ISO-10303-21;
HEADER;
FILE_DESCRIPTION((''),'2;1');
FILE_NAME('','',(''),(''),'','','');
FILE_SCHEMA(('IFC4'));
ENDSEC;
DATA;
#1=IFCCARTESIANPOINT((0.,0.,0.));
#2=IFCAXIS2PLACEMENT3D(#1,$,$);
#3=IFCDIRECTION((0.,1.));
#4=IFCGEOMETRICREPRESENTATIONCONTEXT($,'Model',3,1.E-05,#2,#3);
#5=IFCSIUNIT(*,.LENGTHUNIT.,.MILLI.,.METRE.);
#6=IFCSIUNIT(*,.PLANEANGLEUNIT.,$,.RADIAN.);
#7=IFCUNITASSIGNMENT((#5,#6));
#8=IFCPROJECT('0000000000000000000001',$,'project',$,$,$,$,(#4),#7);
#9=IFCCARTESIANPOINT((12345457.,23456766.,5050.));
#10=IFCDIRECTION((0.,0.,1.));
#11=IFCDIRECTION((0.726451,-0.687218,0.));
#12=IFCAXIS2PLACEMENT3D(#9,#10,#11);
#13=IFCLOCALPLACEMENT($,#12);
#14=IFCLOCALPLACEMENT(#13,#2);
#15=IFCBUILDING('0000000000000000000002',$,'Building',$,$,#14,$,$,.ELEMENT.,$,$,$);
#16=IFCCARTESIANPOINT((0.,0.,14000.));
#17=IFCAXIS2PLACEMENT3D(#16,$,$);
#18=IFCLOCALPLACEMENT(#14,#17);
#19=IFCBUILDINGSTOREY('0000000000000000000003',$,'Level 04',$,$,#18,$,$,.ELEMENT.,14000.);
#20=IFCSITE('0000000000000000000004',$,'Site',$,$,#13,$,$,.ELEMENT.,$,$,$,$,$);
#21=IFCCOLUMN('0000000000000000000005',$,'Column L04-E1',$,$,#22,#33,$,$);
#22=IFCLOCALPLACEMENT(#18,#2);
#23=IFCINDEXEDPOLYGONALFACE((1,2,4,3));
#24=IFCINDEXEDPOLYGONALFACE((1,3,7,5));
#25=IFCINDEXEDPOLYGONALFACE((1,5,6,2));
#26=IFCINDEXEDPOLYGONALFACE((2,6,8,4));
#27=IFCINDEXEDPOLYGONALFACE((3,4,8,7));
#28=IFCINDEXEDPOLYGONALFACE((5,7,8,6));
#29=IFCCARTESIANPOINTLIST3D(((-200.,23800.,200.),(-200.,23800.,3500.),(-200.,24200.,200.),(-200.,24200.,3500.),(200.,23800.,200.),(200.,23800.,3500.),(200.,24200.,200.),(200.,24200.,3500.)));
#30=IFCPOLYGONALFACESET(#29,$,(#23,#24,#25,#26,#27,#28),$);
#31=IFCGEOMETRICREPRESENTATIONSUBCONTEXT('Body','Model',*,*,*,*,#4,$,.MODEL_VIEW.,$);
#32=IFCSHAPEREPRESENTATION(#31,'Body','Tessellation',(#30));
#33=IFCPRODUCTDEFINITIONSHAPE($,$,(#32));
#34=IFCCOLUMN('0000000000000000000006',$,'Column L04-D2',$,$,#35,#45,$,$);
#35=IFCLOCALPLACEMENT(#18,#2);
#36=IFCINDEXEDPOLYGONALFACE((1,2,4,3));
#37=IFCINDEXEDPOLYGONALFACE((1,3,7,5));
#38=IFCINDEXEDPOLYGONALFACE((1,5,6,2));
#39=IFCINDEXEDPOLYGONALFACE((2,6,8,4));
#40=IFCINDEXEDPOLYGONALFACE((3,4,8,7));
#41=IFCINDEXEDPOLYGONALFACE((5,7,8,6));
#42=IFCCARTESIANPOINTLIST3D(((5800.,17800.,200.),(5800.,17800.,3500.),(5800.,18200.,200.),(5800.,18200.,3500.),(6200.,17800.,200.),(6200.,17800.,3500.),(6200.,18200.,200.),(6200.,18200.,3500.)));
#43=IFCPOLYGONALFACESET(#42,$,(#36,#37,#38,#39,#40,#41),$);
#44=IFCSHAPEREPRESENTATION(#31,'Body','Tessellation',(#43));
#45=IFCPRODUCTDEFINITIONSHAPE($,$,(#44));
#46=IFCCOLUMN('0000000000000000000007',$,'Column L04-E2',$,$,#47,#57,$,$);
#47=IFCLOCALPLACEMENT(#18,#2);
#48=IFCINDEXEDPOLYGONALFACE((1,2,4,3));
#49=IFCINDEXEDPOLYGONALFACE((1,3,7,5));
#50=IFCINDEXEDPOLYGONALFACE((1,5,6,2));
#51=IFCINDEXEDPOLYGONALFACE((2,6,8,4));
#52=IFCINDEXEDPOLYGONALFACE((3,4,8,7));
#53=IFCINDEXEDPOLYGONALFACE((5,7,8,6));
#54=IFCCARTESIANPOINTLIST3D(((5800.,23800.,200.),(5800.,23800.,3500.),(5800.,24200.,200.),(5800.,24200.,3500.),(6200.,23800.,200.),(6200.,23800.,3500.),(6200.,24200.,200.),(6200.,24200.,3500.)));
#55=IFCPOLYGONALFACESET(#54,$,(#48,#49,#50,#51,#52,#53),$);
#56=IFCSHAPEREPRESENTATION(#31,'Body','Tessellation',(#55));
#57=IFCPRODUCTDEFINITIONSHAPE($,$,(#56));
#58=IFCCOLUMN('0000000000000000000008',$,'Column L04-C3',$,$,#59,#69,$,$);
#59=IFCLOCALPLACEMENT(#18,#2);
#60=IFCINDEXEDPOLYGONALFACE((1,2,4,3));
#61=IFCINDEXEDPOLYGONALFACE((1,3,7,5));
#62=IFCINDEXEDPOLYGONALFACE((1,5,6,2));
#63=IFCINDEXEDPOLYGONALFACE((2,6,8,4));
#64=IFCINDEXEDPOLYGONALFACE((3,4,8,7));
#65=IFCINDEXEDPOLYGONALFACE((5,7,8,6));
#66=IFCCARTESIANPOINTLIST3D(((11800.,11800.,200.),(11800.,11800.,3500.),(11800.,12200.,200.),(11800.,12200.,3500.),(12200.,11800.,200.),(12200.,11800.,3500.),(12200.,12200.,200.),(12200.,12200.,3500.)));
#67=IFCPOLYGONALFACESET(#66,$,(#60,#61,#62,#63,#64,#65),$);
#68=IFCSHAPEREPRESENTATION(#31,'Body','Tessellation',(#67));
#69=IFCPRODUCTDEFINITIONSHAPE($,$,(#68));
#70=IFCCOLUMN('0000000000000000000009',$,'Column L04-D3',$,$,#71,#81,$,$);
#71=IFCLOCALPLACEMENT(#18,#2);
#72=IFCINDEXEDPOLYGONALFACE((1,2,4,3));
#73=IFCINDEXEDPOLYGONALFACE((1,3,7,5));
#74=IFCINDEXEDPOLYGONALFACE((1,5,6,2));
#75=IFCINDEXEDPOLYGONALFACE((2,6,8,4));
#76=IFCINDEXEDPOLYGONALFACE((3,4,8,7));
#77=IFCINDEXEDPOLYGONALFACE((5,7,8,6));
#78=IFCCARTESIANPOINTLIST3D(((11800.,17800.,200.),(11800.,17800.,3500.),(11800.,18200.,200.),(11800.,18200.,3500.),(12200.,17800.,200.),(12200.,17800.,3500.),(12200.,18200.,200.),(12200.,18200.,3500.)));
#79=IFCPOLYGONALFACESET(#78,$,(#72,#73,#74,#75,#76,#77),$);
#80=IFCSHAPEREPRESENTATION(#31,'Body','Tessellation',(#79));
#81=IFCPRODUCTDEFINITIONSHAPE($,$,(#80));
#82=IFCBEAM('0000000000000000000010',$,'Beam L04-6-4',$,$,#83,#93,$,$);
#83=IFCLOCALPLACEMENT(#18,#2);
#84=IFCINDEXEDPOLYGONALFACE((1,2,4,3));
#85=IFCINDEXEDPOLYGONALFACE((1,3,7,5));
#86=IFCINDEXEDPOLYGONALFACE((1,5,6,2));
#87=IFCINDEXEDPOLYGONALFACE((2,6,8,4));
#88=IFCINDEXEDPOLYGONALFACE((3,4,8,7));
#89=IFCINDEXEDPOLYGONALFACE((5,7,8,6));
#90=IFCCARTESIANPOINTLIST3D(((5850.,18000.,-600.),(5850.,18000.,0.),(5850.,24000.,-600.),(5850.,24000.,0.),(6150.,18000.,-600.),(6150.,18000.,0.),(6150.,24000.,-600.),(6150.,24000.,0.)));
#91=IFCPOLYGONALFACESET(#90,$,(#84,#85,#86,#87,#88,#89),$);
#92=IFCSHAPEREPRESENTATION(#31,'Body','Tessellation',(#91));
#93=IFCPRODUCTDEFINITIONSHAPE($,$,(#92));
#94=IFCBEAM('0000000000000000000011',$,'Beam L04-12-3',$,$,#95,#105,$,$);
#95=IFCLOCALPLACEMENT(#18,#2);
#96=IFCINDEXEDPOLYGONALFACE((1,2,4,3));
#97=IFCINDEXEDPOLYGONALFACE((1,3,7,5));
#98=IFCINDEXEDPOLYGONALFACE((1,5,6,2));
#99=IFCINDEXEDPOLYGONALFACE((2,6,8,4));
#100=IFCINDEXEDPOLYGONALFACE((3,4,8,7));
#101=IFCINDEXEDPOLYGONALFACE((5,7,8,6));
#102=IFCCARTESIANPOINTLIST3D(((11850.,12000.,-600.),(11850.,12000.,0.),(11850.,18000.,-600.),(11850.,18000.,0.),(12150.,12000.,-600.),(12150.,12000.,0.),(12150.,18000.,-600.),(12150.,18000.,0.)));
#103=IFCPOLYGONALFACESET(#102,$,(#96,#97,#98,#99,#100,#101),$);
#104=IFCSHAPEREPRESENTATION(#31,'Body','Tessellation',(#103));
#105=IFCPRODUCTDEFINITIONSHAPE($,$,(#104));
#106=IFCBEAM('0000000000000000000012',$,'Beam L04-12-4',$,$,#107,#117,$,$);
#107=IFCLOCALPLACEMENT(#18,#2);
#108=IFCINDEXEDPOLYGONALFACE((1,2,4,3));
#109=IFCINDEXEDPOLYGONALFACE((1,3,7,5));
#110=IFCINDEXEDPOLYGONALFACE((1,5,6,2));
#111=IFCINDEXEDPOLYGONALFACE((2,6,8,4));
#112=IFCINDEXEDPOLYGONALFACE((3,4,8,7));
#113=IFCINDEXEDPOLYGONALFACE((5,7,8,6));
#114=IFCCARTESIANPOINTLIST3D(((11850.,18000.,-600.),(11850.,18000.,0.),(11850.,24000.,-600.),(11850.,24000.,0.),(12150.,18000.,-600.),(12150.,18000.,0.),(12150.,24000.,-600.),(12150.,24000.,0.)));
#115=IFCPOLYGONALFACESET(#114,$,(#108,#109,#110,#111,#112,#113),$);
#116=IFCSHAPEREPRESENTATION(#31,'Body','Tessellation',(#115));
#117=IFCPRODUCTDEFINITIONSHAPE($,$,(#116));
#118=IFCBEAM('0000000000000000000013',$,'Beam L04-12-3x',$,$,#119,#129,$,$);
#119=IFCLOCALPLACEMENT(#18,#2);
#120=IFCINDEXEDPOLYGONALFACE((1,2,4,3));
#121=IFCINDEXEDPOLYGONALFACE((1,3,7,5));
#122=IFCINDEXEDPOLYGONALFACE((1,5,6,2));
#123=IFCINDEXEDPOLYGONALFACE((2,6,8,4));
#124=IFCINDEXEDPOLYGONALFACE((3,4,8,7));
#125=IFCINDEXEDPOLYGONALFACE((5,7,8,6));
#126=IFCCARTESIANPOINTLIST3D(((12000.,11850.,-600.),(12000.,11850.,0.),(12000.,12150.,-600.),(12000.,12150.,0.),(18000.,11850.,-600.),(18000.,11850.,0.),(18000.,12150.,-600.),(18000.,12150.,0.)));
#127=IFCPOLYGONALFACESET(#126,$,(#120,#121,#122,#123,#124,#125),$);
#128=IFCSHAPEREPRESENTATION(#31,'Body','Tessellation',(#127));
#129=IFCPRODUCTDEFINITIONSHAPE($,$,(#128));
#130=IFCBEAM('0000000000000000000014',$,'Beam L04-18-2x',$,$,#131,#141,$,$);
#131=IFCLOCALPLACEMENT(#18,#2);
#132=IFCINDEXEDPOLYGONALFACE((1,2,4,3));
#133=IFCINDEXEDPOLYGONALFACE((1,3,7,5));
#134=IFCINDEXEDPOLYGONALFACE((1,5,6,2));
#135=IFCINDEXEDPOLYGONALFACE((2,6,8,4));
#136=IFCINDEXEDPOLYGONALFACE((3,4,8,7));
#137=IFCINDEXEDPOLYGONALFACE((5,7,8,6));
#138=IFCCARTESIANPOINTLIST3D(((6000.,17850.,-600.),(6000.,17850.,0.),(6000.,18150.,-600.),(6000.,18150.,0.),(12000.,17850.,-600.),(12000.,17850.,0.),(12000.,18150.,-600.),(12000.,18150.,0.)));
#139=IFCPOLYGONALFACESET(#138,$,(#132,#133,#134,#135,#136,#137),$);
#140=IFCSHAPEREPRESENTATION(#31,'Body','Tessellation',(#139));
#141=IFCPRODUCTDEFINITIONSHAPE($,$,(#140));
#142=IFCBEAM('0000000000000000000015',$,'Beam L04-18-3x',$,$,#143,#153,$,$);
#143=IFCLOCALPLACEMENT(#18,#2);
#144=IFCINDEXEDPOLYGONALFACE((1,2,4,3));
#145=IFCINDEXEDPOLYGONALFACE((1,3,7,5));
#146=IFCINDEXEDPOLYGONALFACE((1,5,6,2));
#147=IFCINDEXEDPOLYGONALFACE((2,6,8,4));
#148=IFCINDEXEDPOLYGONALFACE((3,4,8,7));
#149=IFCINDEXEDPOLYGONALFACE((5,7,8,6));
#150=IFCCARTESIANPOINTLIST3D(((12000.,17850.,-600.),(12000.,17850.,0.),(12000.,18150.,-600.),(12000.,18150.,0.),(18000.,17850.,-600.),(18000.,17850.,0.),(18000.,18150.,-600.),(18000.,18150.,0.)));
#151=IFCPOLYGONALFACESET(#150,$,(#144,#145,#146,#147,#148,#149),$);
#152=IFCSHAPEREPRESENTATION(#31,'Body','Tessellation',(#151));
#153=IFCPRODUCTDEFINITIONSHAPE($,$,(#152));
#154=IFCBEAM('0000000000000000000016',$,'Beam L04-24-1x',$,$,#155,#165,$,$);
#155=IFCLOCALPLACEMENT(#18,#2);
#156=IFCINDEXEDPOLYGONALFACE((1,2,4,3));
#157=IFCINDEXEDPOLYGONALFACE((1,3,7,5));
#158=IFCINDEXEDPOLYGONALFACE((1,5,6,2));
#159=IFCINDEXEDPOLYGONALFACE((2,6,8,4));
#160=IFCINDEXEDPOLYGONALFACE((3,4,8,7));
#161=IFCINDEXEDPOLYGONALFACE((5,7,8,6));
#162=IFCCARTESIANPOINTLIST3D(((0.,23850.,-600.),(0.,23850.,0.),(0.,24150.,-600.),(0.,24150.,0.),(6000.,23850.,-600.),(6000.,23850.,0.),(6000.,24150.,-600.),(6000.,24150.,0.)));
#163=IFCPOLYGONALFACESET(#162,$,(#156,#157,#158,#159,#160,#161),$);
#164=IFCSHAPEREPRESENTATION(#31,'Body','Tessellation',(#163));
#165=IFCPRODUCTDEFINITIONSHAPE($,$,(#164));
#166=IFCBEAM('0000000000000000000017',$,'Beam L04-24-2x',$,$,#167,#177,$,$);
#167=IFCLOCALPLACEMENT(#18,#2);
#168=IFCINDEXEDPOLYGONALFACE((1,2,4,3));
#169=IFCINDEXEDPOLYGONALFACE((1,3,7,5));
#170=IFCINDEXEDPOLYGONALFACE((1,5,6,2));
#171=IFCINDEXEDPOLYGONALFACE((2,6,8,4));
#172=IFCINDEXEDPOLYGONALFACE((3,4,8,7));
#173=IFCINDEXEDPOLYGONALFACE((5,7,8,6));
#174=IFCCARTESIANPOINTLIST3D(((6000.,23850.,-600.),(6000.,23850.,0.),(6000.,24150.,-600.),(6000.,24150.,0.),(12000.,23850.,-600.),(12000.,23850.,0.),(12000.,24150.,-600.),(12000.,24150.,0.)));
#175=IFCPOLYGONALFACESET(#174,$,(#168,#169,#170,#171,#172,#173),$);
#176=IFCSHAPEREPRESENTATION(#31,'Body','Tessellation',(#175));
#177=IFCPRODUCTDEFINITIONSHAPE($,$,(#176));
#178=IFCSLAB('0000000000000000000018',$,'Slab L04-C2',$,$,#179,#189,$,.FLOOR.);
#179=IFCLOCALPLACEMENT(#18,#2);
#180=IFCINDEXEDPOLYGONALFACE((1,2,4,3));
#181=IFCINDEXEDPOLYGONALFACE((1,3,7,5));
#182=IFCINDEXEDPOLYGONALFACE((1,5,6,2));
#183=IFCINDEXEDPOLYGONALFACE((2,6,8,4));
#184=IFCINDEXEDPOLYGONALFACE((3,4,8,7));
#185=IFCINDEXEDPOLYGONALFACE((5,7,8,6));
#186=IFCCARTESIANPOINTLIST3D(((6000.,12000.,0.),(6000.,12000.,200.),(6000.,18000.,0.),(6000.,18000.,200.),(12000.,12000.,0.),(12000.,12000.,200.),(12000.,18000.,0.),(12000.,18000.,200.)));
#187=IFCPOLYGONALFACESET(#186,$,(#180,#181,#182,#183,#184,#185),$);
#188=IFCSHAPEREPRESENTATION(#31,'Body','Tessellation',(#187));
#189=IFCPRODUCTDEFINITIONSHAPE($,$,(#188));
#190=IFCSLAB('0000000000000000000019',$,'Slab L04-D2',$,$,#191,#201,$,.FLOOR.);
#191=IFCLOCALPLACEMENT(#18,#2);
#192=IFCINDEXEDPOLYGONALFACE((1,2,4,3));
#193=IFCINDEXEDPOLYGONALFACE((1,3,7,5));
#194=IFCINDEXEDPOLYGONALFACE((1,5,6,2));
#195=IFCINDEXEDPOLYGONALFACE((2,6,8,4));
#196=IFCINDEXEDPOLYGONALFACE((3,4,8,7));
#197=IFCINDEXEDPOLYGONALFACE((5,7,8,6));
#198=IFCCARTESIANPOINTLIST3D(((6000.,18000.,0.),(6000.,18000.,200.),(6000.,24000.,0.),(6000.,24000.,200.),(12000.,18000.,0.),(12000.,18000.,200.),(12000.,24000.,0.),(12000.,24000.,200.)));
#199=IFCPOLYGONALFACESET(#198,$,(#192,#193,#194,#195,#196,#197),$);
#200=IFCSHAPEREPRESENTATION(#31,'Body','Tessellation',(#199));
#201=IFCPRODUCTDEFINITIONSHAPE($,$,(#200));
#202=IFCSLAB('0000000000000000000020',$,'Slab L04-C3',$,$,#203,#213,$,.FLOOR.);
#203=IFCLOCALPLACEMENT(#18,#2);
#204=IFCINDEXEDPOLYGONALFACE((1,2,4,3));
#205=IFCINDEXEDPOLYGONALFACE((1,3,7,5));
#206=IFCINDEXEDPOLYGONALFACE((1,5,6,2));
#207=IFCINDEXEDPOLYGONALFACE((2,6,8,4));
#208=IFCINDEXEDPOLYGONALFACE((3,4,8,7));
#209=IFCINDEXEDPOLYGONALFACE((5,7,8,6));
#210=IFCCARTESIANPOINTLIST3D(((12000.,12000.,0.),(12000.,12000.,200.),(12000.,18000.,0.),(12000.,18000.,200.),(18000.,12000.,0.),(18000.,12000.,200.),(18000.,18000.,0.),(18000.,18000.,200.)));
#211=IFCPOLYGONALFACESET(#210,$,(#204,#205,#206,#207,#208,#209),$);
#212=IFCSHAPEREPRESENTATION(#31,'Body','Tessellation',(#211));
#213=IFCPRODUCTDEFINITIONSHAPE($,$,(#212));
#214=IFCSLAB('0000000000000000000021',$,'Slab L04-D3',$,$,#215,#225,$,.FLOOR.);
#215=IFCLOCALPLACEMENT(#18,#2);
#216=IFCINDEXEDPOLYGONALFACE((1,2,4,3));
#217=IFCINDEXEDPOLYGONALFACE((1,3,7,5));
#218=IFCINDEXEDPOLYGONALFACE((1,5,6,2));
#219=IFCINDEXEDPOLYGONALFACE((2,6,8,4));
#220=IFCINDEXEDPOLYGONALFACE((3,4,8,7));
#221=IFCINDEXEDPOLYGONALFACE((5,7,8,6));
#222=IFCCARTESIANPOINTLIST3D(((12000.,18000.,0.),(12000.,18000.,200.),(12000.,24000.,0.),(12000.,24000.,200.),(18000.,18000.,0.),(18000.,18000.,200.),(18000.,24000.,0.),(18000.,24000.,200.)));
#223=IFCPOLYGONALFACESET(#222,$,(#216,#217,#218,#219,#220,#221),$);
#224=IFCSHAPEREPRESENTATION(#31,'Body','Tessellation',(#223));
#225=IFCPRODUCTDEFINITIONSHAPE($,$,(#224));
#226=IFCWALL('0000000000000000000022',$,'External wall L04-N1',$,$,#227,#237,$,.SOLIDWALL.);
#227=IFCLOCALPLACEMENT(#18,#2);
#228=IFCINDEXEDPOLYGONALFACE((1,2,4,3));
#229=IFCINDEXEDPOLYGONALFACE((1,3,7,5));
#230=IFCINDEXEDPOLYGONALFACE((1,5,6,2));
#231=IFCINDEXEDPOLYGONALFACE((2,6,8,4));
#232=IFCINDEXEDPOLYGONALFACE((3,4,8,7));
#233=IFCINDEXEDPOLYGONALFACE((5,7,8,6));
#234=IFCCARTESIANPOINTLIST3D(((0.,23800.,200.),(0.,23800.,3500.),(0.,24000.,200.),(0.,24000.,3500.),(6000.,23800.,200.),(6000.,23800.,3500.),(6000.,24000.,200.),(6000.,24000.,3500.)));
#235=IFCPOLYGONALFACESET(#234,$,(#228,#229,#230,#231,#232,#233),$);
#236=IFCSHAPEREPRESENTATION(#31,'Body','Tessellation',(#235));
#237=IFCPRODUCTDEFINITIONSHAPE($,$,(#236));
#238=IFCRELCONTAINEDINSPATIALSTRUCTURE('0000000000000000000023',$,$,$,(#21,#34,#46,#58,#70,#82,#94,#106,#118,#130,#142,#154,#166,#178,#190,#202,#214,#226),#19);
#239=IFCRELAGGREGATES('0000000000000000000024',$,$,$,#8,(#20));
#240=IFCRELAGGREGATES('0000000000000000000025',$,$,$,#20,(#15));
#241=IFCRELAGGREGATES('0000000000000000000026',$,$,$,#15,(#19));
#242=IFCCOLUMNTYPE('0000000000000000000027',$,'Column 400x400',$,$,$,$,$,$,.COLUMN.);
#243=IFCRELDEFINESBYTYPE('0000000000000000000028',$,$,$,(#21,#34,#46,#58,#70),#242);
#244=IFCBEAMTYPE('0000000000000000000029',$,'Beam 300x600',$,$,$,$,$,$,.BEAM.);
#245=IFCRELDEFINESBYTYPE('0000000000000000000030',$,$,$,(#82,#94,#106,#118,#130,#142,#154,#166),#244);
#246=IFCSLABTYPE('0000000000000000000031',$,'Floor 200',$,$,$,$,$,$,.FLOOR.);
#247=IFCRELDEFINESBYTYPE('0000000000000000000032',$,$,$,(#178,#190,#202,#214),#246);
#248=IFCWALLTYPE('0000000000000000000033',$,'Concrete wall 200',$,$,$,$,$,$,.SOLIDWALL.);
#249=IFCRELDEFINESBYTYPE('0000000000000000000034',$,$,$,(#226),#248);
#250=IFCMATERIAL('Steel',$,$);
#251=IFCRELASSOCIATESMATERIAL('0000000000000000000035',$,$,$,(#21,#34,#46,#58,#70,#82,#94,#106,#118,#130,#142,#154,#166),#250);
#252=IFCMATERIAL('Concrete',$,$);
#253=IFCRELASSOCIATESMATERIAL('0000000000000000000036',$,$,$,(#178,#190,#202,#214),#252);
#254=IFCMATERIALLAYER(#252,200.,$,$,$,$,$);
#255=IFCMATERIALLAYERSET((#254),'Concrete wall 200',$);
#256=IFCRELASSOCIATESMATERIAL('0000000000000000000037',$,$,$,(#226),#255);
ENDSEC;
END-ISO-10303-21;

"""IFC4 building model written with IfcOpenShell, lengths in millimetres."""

from ifc_helpers import new_model, si_unit, direction, frame, origin, place, context, subcontext, project, spatial, rectangle, extrude, material, layer, layer_set, layer_usage, type_object, element, save


model = new_model("IFC4")

# Units and contexts
model_context = context("Model", 3, precision=1e-05, world=origin(), true_north=direction((0.0, 1.0)))
body_context = subcontext(model_context, "Body", "Model", "MODEL_VIEW")
ifc_project = project(units=[si_unit("LENGTHUNIT", "METRE", prefix="MILLI"), si_unit("PLANEANGLEUNIT", "RADIAN")], contexts=[model_context])

# Site, building, storey
site_placement = place(None, frame((12345457.0, 23456766.0, 5050.0), z_axis=(0.0, 0.0, 1.0), x_axis=(0.726451, -0.687218, 0.0)))
site = spatial("IfcSite", under=ifc_project, at=site_placement, Name="Site", CompositionType="ELEMENT")
building_placement = place(site_placement, origin())
building = spatial("IfcBuilding", under=site, at=building_placement, Name="Building", CompositionType="ELEMENT")
storey_placement = place(building_placement, frame((0.0, 0.0, 14000.0)))
storey = spatial("IfcBuildingStorey", under=building, at=storey_placement, Name="Level 04", CompositionType="ELEMENT", Elevation=14000.0)

# Columns
ifc_material_1 = material(Name="Steel")
column_type = type_object("IfcColumnType", Name="Column 400x400", PredefinedType="COLUMN")
for number, where, name in (
    (1, (-200.0, 23800.0, 200.0), "Column L04-E1"),
    (2, (5800.0, 17800.0, 200.0), "Column L04-D2"),
    (3, (5800.0, 23800.0, 200.0), "Column L04-E2"),
    (4, (11800.0, 11800.0, 200.0), "Column L04-C3"),
    (5, (11800.0, 17800.0, 200.0), "Column L04-D3"),
):
    element("IfcColumn", number, at=place(storey_placement, frame(where)), inside=storey, type_object=column_type, material=ifc_material_1, Name=name, context=body_context, shape_type="SweptSolid", body=[
        extrude(rectangle(XDim=400.0, YDim=400.0), frame((200.0, 200.0, 0.0)), (0.0, 0.0, 1.0), 3300.0),
    ])

# Beams
beam_type = type_object("IfcBeamType", Name="Beam 300x600", PredefinedType="BEAM")
for number, where, name in (
    (6, (5850.0, 18000.0, -600.0), "Beam L04-6-4"),
    (7, (11850.0, 12000.0, -600.0), "Beam L04-12-3"),
    (8, (11850.0, 18000.0, -600.0), "Beam L04-12-4"),
):
    element("IfcBeam", number, at=place(storey_placement, frame(where)), inside=storey, type_object=beam_type, material=ifc_material_1, Name=name, context=body_context, shape_type="SweptSolid", body=[
        extrude(rectangle(XDim=300.0, YDim=6000.0), frame((150.0, 3000.0, 0.0)), (0.0, 0.0, 1.0), 600.0),
    ])
for number, where, name in (
    (9, (12000.0, 11850.0, -600.0), "Beam L04-12-3x"),
    (10, (6000.0, 17850.0, -600.0), "Beam L04-18-2x"),
    (11, (12000.0, 17850.0, -600.0), "Beam L04-18-3x"),
    (12, (0.0, 23850.0, -600.0), "Beam L04-24-1x"),
    (13, (6000.0, 23850.0, -600.0), "Beam L04-24-2x"),
):
    element("IfcBeam", number, at=place(storey_placement, frame(where)), inside=storey, type_object=beam_type, material=ifc_material_1, Name=name, context=body_context, shape_type="SweptSolid", body=[
        extrude(rectangle(XDim=6000.0, YDim=300.0), frame((3000.0, 150.0, 0.0)), (0.0, 0.0, 1.0), 600.0),
    ])

# Slabs
ifc_material_2 = material(Name="Concrete")
slab_type = type_object("IfcSlabType", Name="Floor 200", PredefinedType="FLOOR")
for number, where, name in (
    (14, (6000.0, 12000.0, 0.0), "Slab L04-C2"),
    (15, (6000.0, 18000.0, 0.0), "Slab L04-D2"),
    (16, (12000.0, 12000.0, 0.0), "Slab L04-C3"),
    (17, (12000.0, 18000.0, 0.0), "Slab L04-D3"),
):
    element("IfcSlab", number, at=place(storey_placement, frame(where)), inside=storey, type_object=slab_type, material=ifc_material_2, Name=name, PredefinedType="FLOOR", context=body_context, shape_type="SweptSolid", body=[
        extrude(rectangle(XDim=6000.0, YDim=6000.0), frame((3000.0, 3000.0, 0.0)), (0.0, 0.0, 1.0), 200.0),
    ])

# Wall
ifc_layer_1 = layer(ifc_material_2, 200.0)
ifc_layer_set_1 = layer_set([ifc_layer_1], Name="Concrete wall 200")
ifc_layer_usage_1 = layer_usage(ifc_layer_set_1, "AXIS2", "POSITIVE", 0.0)
wall_type_1 = type_object("IfcWallType", Name="Concrete wall 200", PredefinedType="SOLIDWALL")
for number, where, name in (
    (18, (0.0, 23800.0, 200.0), "External wall L04-N1"),
):
    element("IfcWall", number, at=place(storey_placement, frame(where)), inside=storey, type_object=wall_type_1, material=ifc_layer_usage_1, Name=name, PredefinedType="SOLIDWALL", context=body_context, shape_type="SweptSolid", body=[
        extrude(rectangle(XDim=6000.0, YDim=200.0), frame((3000.0, 100.0, 0.0)), (0.0, 0.0, 1.0), 3300.0),
    ])

save(model, "model.ifc")
